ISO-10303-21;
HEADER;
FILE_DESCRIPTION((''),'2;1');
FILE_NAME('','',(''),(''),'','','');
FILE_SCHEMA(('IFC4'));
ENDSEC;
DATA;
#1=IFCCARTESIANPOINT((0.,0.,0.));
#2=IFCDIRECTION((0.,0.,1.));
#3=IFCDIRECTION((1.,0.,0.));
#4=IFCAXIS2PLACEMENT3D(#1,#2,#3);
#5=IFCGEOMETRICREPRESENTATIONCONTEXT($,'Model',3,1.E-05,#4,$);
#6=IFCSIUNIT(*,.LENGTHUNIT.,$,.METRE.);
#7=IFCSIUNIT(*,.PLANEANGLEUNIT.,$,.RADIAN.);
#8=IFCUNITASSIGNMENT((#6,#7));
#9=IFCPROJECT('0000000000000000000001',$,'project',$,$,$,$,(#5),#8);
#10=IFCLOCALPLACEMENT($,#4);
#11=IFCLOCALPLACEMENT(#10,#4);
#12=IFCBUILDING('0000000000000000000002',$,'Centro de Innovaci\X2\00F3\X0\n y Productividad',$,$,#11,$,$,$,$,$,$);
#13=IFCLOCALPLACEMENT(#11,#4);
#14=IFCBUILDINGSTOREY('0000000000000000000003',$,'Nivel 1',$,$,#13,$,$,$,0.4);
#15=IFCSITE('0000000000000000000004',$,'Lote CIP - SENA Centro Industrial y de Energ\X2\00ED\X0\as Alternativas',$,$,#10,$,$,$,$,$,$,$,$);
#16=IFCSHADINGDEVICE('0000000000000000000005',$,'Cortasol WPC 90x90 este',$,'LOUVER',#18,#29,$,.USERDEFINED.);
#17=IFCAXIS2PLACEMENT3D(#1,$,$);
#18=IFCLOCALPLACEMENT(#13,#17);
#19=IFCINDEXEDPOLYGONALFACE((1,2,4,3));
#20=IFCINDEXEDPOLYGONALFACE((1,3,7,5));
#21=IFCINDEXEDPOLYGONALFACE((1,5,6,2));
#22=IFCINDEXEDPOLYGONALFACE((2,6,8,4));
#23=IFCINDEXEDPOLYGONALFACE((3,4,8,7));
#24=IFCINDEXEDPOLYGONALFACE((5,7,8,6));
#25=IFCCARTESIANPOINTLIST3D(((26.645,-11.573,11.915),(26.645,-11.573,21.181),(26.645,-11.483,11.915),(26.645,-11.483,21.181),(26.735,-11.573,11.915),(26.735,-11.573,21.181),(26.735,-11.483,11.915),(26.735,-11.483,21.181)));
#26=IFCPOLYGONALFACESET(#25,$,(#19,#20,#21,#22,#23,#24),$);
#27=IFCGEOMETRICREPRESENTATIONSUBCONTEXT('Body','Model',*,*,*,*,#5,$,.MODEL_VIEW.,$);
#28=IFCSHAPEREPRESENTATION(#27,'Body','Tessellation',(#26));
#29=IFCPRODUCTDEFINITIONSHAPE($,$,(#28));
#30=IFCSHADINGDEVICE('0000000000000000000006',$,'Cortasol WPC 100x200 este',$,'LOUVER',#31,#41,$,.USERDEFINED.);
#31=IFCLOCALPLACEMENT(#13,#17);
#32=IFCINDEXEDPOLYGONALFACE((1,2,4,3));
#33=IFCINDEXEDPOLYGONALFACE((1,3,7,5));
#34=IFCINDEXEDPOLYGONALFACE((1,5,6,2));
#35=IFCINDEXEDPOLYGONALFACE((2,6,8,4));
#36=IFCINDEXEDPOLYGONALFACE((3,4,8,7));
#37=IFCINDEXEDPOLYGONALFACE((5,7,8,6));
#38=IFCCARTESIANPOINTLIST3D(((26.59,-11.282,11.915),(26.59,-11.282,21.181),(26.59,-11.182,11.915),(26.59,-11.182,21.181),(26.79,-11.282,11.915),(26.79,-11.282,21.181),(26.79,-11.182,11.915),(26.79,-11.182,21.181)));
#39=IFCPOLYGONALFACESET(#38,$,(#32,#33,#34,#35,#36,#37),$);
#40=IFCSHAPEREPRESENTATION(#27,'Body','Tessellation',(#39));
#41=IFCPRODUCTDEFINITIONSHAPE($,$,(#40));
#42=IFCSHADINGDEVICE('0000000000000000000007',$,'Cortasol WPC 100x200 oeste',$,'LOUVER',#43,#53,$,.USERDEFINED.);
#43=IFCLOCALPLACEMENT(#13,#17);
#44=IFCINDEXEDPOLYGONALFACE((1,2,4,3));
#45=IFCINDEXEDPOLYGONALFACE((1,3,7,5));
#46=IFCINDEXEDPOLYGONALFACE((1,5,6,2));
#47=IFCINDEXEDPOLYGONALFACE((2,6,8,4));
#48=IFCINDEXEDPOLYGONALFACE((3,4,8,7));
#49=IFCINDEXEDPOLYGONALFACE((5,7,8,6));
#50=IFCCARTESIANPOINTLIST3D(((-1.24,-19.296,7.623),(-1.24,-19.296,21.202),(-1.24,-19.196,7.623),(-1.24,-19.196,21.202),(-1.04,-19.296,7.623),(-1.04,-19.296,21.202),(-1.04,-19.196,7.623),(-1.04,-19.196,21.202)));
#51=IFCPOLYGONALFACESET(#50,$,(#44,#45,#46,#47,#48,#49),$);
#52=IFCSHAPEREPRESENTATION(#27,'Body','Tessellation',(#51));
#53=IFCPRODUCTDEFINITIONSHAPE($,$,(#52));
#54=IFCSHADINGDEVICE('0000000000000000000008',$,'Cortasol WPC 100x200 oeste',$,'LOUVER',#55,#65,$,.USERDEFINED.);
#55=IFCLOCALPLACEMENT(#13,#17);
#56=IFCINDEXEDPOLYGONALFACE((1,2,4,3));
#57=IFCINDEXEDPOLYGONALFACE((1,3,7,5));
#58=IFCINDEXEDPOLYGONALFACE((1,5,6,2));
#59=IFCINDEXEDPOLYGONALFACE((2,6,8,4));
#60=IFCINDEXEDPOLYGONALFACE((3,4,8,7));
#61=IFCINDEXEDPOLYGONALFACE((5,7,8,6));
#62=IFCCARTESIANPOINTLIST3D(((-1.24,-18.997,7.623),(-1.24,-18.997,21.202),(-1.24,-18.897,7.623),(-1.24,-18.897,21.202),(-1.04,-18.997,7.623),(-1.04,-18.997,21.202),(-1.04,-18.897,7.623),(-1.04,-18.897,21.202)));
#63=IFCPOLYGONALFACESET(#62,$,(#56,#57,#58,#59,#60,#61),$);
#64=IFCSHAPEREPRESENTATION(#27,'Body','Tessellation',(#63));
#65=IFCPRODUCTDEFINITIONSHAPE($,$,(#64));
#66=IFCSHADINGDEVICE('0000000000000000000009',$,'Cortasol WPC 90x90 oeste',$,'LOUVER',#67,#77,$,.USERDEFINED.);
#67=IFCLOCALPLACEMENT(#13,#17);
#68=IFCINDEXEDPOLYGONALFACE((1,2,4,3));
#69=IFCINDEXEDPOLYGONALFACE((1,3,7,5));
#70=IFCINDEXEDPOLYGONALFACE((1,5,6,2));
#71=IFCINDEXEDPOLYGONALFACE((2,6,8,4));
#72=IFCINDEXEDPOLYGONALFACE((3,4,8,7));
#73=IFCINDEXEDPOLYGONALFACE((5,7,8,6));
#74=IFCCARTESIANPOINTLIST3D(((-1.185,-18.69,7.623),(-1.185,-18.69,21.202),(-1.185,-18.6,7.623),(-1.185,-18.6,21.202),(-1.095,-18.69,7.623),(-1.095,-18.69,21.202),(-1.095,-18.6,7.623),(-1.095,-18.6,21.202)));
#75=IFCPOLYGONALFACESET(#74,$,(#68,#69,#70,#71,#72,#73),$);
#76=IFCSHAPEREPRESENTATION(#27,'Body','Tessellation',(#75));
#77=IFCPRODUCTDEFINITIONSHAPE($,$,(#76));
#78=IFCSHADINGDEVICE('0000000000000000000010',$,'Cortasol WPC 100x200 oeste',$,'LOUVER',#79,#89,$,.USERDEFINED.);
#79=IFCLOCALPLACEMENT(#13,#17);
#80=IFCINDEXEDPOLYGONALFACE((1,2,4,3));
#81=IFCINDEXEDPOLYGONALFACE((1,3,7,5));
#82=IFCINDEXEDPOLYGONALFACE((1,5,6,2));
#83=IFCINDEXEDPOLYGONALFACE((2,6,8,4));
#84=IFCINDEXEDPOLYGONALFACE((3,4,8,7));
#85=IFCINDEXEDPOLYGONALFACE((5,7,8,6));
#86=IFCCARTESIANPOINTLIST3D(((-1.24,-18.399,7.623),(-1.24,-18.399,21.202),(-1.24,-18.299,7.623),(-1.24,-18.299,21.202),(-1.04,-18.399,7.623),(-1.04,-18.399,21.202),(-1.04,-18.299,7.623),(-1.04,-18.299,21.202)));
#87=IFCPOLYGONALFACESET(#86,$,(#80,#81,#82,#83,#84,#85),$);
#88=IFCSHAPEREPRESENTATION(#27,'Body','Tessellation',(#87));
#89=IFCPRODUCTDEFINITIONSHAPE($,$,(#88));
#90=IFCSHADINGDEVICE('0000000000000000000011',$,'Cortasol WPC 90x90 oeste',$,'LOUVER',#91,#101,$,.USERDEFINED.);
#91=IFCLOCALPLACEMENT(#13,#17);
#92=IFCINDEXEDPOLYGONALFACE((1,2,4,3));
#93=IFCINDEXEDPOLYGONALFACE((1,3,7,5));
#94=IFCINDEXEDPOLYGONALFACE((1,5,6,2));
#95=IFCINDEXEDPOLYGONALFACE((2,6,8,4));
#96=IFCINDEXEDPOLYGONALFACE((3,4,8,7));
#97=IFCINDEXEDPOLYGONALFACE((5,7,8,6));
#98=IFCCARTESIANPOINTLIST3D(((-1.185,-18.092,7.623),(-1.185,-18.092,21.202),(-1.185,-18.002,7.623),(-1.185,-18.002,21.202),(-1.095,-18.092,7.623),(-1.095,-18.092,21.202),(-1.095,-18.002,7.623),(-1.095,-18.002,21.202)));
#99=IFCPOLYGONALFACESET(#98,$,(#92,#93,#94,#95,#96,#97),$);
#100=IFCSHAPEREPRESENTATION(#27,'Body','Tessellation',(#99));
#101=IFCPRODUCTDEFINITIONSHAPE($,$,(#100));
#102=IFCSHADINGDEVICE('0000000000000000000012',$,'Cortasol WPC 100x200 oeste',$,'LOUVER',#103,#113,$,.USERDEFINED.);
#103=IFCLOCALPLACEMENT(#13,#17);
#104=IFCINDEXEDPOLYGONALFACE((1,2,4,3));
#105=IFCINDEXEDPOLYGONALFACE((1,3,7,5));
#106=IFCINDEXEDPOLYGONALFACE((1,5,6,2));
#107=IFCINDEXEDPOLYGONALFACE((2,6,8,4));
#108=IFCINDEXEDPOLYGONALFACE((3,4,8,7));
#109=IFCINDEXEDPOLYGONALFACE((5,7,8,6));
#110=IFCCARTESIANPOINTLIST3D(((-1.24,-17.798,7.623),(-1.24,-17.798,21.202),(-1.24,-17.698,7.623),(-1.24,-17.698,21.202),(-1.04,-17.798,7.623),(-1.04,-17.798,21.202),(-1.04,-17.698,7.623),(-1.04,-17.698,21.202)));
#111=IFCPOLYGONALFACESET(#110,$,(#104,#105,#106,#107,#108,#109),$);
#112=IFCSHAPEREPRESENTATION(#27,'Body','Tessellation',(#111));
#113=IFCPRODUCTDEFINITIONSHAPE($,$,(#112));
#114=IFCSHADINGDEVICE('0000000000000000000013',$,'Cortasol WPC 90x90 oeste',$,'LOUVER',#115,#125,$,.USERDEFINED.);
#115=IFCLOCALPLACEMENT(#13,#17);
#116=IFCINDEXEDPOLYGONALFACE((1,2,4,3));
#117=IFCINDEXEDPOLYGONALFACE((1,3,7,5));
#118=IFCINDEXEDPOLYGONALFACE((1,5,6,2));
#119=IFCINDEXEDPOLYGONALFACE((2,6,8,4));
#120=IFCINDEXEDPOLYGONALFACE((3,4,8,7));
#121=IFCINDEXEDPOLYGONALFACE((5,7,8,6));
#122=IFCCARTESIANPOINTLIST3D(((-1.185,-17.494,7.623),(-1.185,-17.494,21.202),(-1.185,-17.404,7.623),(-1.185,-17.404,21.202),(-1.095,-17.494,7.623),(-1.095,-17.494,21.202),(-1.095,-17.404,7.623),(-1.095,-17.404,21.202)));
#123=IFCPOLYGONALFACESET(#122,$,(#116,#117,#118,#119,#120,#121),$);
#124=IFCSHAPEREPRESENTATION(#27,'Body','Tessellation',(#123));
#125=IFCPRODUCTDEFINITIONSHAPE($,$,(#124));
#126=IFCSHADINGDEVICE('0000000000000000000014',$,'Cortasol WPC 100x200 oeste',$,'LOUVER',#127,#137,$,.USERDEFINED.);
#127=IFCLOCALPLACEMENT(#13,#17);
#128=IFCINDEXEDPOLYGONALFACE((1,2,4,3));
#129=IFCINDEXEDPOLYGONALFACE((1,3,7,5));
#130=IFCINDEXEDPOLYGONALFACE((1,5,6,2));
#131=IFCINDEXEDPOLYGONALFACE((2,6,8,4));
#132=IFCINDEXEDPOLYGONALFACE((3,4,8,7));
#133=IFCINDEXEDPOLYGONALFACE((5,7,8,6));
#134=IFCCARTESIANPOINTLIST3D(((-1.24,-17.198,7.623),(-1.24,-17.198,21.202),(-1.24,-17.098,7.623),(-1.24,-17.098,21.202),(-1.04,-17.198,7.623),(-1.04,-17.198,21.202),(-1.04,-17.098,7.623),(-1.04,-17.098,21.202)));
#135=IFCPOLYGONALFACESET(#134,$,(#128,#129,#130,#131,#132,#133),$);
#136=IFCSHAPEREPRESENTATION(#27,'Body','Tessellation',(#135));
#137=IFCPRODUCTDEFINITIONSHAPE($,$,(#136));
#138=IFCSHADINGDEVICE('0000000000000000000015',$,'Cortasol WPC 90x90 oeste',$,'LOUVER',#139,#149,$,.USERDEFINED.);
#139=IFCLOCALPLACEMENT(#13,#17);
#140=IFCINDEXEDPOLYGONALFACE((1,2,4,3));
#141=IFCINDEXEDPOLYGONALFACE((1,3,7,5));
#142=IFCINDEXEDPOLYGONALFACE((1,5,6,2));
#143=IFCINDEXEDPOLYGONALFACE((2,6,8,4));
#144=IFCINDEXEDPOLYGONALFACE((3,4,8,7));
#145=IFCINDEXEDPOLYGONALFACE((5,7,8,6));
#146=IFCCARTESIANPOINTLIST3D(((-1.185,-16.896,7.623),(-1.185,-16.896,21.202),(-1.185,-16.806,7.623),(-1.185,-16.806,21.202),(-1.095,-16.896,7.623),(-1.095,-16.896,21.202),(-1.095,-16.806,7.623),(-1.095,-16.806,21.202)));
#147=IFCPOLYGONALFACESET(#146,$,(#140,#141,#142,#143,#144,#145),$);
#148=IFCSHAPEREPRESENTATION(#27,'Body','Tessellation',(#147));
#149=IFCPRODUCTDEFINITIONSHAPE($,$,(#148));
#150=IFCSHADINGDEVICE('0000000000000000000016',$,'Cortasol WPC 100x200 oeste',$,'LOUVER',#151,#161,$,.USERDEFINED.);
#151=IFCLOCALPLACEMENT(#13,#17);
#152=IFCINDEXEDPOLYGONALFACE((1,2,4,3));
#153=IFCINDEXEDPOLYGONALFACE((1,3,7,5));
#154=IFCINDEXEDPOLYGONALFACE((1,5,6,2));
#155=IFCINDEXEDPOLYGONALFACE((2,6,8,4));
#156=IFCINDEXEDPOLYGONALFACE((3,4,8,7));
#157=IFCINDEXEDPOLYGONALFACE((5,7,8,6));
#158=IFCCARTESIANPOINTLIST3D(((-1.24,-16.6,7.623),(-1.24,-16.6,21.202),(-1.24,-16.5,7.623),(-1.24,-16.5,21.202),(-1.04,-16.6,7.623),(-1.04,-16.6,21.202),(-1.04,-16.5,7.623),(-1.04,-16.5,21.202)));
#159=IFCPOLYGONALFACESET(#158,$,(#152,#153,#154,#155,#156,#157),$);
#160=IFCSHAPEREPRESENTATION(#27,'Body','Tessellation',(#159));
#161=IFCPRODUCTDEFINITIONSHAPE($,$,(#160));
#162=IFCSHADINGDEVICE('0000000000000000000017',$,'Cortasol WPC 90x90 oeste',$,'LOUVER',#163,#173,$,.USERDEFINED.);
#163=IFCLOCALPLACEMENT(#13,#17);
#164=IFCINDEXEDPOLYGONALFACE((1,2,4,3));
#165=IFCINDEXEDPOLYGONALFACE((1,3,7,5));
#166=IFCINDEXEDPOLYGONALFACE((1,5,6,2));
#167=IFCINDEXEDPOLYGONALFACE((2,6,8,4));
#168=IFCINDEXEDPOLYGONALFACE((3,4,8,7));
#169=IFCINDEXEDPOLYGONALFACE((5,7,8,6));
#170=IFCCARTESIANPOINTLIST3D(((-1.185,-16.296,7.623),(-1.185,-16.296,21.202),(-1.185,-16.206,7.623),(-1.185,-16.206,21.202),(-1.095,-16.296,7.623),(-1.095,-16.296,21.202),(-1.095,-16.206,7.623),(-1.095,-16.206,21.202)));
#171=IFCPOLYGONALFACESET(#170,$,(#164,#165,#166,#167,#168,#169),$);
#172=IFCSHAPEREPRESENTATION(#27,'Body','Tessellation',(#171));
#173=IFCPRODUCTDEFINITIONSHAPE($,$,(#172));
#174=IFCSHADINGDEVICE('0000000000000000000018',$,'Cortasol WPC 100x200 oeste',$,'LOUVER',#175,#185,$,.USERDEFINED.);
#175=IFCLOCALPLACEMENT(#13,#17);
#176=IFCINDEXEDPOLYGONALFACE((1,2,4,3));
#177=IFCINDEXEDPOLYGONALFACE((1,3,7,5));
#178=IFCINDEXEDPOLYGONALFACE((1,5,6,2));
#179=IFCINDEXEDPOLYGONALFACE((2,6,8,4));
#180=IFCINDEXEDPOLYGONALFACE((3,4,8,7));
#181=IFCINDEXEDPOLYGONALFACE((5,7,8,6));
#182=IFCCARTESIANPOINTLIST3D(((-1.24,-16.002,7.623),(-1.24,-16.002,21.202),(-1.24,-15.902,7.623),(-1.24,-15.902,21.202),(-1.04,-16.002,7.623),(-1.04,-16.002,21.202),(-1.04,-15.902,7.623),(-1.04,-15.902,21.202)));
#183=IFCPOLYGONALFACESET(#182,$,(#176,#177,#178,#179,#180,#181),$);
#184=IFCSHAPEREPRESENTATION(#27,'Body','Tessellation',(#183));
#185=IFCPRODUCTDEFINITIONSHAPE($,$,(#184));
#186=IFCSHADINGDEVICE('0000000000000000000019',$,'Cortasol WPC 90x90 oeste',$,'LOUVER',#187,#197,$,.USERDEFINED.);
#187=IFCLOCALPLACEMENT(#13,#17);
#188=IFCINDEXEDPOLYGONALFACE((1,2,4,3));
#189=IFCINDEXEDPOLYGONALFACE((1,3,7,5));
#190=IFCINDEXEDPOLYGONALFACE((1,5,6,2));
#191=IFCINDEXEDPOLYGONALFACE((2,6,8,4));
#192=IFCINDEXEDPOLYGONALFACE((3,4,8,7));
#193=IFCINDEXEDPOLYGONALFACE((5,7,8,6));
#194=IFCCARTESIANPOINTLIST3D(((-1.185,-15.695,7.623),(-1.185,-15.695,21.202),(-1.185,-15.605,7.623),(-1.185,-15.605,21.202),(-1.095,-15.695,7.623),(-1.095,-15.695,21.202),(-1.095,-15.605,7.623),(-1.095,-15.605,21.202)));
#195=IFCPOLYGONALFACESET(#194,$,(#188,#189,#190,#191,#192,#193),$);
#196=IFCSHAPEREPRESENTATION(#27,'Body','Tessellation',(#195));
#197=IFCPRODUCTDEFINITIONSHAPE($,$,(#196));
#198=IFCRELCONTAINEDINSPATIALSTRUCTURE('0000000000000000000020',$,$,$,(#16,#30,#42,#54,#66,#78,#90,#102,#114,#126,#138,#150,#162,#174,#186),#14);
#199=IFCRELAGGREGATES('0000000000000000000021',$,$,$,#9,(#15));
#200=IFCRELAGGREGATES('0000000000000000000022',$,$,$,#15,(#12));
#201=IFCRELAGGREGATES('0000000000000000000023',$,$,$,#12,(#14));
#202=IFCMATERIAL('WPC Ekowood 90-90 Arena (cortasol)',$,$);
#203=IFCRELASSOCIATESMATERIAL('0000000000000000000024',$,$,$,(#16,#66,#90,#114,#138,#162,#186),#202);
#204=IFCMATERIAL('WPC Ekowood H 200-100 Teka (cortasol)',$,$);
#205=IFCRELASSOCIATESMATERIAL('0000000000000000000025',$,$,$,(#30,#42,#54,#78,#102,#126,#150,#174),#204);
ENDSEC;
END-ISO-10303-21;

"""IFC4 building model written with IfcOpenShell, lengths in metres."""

from ifc_helpers import new_model, si_unit, frame, origin_with_axes, place, context, subcontext, project, spatial, polyline, outline, extrude, material, element, save


model = new_model("IFC4")

# Units and contexts
model_context = context("Model", 3, precision=1e-05, world=origin_with_axes())
body_context = subcontext(model_context, "Body", "Model", "MODEL_VIEW")
ifc_project = project(units=[si_unit("LENGTHUNIT", "METRE"), si_unit("PLANEANGLEUNIT", "RADIAN")], contexts=[model_context])

# Site, building, storey
site_placement = place(None, origin_with_axes())
site = spatial("IfcSite", under=ifc_project, at=site_placement, Name="Lote CIP - SENA Centro Industrial y de Energías Alternativas")
building_placement = place(site_placement, origin_with_axes())
building = spatial("IfcBuilding", under=site, at=building_placement, Name="Centro de Innovación y Productividad")
storey_placement = place(building_placement, origin_with_axes())
storey = spatial("IfcBuildingStorey", under=building, at=storey_placement, Name="Nivel 1", Elevation=0.4)

# Shading devices
ifc_material_1 = material(Name="WPC Ekowood 90-90 Arena (cortasol)")
shading_device_1_placement = place(storey_placement, origin_with_axes())
element("IfcShadingDevice", 1, at=shading_device_1_placement, inside=storey, material=ifc_material_1, Name="Cortasol WPC 90x90 este", ObjectType="LOUVER", PredefinedType="USERDEFINED", context=body_context, shape_type="SweptSolid", body=[
    extrude(outline(polyline([(26.735, -11.573), (26.645, -11.573), (26.645, -11.483), (26.735, -11.483), (26.735, -11.573)])), frame((0.0, 0.0, 11.915)), (0.0, 0.0, 1.0), 9.266),
])
ifc_material_2 = material(Name="WPC Ekowood H 200-100 Teka (cortasol)")
shading_device_2_placement = place(storey_placement, origin_with_axes())
element("IfcShadingDevice", 2, at=shading_device_2_placement, inside=storey, material=ifc_material_2, Name="Cortasol WPC 100x200 este", ObjectType="LOUVER", PredefinedType="USERDEFINED", context=body_context, shape_type="SweptSolid", body=[
    extrude(outline(polyline([(26.79, -11.282), (26.59, -11.282), (26.59, -11.182), (26.79, -11.182), (26.79, -11.282)])), frame((0.0, 0.0, 11.915)), (0.0, 0.0, 1.0), 9.266),
])
shading_device_3_placement = place(storey_placement, origin_with_axes())
element("IfcShadingDevice", 3, at=shading_device_3_placement, inside=storey, material=ifc_material_2, Name="Cortasol WPC 100x200 oeste", ObjectType="LOUVER", PredefinedType="USERDEFINED", context=body_context, shape_type="SweptSolid", body=[
    extrude(outline(polyline([(-1.04, -19.296), (-1.24, -19.296), (-1.24, -19.196), (-1.04, -19.196), (-1.04, -19.296)])), frame((0.0, 0.0, 7.623)), (0.0, 0.0, 1.0), 13.579),
])
shading_device_4_placement = place(storey_placement, origin_with_axes())
element("IfcShadingDevice", 4, at=shading_device_4_placement, inside=storey, material=ifc_material_2, Name="Cortasol WPC 100x200 oeste", ObjectType="LOUVER", PredefinedType="USERDEFINED", context=body_context, shape_type="SweptSolid", body=[
    extrude(outline(polyline([(-1.04, -18.997), (-1.24, -18.997), (-1.24, -18.897), (-1.04, -18.897), (-1.04, -18.997)])), frame((0.0, 0.0, 7.623)), (0.0, 0.0, 1.0), 13.579),
])
shading_device_5_placement = place(storey_placement, origin_with_axes())
element("IfcShadingDevice", 5, at=shading_device_5_placement, inside=storey, material=ifc_material_1, Name="Cortasol WPC 90x90 oeste", ObjectType="LOUVER", PredefinedType="USERDEFINED", context=body_context, shape_type="SweptSolid", body=[
    extrude(outline(polyline([(-1.095, -18.69), (-1.185, -18.69), (-1.185, -18.6), (-1.095, -18.6), (-1.095, -18.69)])), frame((0.0, 0.0, 7.623)), (0.0, 0.0, 1.0), 13.579),
])
shading_device_6_placement = place(storey_placement, origin_with_axes())
element("IfcShadingDevice", 6, at=shading_device_6_placement, inside=storey, material=ifc_material_2, Name="Cortasol WPC 100x200 oeste", ObjectType="LOUVER", PredefinedType="USERDEFINED", context=body_context, shape_type="SweptSolid", body=[
    extrude(outline(polyline([(-1.04, -18.399), (-1.24, -18.399), (-1.24, -18.299), (-1.04, -18.299), (-1.04, -18.399)])), frame((0.0, 0.0, 7.623)), (0.0, 0.0, 1.0), 13.579),
])
shading_device_7_placement = place(storey_placement, origin_with_axes())
element("IfcShadingDevice", 7, at=shading_device_7_placement, inside=storey, material=ifc_material_1, Name="Cortasol WPC 90x90 oeste", ObjectType="LOUVER", PredefinedType="USERDEFINED", context=body_context, shape_type="SweptSolid", body=[
    extrude(outline(polyline([(-1.095, -18.092), (-1.185, -18.092), (-1.185, -18.002), (-1.095, -18.002), (-1.095, -18.092)])), frame((0.0, 0.0, 7.623)), (0.0, 0.0, 1.0), 13.579),
])
shading_device_8_placement = place(storey_placement, origin_with_axes())
element("IfcShadingDevice", 8, at=shading_device_8_placement, inside=storey, material=ifc_material_2, Name="Cortasol WPC 100x200 oeste", ObjectType="LOUVER", PredefinedType="USERDEFINED", context=body_context, shape_type="SweptSolid", body=[
    extrude(outline(polyline([(-1.04, -17.798), (-1.24, -17.798), (-1.24, -17.698), (-1.04, -17.698), (-1.04, -17.798)])), frame((0.0, 0.0, 7.623)), (0.0, 0.0, 1.0), 13.579),
])
shading_device_9_placement = place(storey_placement, origin_with_axes())
element("IfcShadingDevice", 9, at=shading_device_9_placement, inside=storey, material=ifc_material_1, Name="Cortasol WPC 90x90 oeste", ObjectType="LOUVER", PredefinedType="USERDEFINED", context=body_context, shape_type="SweptSolid", body=[
    extrude(outline(polyline([(-1.095, -17.494), (-1.185, -17.494), (-1.185, -17.404), (-1.095, -17.404), (-1.095, -17.494)])), frame((0.0, 0.0, 7.623)), (0.0, 0.0, 1.0), 13.579),
])
shading_device_10_placement = place(storey_placement, origin_with_axes())
element("IfcShadingDevice", 10, at=shading_device_10_placement, inside=storey, material=ifc_material_2, Name="Cortasol WPC 100x200 oeste", ObjectType="LOUVER", PredefinedType="USERDEFINED", context=body_context, shape_type="SweptSolid", body=[
    extrude(outline(polyline([(-1.04, -17.198), (-1.24, -17.198), (-1.24, -17.098), (-1.04, -17.098), (-1.04, -17.198)])), frame((0.0, 0.0, 7.623)), (0.0, 0.0, 1.0), 13.579),
])
shading_device_11_placement = place(storey_placement, origin_with_axes())
element("IfcShadingDevice", 11, at=shading_device_11_placement, inside=storey, material=ifc_material_1, Name="Cortasol WPC 90x90 oeste", ObjectType="LOUVER", PredefinedType="USERDEFINED", context=body_context, shape_type="SweptSolid", body=[
    extrude(outline(polyline([(-1.095, -16.896), (-1.185, -16.896), (-1.185, -16.806), (-1.095, -16.806), (-1.095, -16.896)])), frame((0.0, 0.0, 7.623)), (0.0, 0.0, 1.0), 13.579),
])
shading_device_12_placement = place(storey_placement, origin_with_axes())
element("IfcShadingDevice", 12, at=shading_device_12_placement, inside=storey, material=ifc_material_2, Name="Cortasol WPC 100x200 oeste", ObjectType="LOUVER", PredefinedType="USERDEFINED", context=body_context, shape_type="SweptSolid", body=[
    extrude(outline(polyline([(-1.04, -16.6), (-1.24, -16.6), (-1.24, -16.5), (-1.04, -16.5), (-1.04, -16.6)])), frame((0.0, 0.0, 7.623)), (0.0, 0.0, 1.0), 13.579),
])
shading_device_13_placement = place(storey_placement, origin_with_axes())
element("IfcShadingDevice", 13, at=shading_device_13_placement, inside=storey, material=ifc_material_1, Name="Cortasol WPC 90x90 oeste", ObjectType="LOUVER", PredefinedType="USERDEFINED", context=body_context, shape_type="SweptSolid", body=[
    extrude(outline(polyline([(-1.095, -16.296), (-1.185, -16.296), (-1.185, -16.206), (-1.095, -16.206), (-1.095, -16.296)])), frame((0.0, 0.0, 7.623)), (0.0, 0.0, 1.0), 13.579),
])
shading_device_14_placement = place(storey_placement, origin_with_axes())
element("IfcShadingDevice", 14, at=shading_device_14_placement, inside=storey, material=ifc_material_2, Name="Cortasol WPC 100x200 oeste", ObjectType="LOUVER", PredefinedType="USERDEFINED", context=body_context, shape_type="SweptSolid", body=[
    extrude(outline(polyline([(-1.04, -16.002), (-1.24, -16.002), (-1.24, -15.902), (-1.04, -15.902), (-1.04, -16.002)])), frame((0.0, 0.0, 7.623)), (0.0, 0.0, 1.0), 13.579),
])
shading_device_15_placement = place(storey_placement, origin_with_axes())
element("IfcShadingDevice", 15, at=shading_device_15_placement, inside=storey, material=ifc_material_1, Name="Cortasol WPC 90x90 oeste", ObjectType="LOUVER", PredefinedType="USERDEFINED", context=body_context, shape_type="SweptSolid", body=[
    extrude(outline(polyline([(-1.095, -15.695), (-1.185, -15.695), (-1.185, -15.605), (-1.095, -15.605), (-1.095, -15.695)])), frame((0.0, 0.0, 7.623)), (0.0, 0.0, 1.0), 13.579),
])

save(model, "model.ifc")
